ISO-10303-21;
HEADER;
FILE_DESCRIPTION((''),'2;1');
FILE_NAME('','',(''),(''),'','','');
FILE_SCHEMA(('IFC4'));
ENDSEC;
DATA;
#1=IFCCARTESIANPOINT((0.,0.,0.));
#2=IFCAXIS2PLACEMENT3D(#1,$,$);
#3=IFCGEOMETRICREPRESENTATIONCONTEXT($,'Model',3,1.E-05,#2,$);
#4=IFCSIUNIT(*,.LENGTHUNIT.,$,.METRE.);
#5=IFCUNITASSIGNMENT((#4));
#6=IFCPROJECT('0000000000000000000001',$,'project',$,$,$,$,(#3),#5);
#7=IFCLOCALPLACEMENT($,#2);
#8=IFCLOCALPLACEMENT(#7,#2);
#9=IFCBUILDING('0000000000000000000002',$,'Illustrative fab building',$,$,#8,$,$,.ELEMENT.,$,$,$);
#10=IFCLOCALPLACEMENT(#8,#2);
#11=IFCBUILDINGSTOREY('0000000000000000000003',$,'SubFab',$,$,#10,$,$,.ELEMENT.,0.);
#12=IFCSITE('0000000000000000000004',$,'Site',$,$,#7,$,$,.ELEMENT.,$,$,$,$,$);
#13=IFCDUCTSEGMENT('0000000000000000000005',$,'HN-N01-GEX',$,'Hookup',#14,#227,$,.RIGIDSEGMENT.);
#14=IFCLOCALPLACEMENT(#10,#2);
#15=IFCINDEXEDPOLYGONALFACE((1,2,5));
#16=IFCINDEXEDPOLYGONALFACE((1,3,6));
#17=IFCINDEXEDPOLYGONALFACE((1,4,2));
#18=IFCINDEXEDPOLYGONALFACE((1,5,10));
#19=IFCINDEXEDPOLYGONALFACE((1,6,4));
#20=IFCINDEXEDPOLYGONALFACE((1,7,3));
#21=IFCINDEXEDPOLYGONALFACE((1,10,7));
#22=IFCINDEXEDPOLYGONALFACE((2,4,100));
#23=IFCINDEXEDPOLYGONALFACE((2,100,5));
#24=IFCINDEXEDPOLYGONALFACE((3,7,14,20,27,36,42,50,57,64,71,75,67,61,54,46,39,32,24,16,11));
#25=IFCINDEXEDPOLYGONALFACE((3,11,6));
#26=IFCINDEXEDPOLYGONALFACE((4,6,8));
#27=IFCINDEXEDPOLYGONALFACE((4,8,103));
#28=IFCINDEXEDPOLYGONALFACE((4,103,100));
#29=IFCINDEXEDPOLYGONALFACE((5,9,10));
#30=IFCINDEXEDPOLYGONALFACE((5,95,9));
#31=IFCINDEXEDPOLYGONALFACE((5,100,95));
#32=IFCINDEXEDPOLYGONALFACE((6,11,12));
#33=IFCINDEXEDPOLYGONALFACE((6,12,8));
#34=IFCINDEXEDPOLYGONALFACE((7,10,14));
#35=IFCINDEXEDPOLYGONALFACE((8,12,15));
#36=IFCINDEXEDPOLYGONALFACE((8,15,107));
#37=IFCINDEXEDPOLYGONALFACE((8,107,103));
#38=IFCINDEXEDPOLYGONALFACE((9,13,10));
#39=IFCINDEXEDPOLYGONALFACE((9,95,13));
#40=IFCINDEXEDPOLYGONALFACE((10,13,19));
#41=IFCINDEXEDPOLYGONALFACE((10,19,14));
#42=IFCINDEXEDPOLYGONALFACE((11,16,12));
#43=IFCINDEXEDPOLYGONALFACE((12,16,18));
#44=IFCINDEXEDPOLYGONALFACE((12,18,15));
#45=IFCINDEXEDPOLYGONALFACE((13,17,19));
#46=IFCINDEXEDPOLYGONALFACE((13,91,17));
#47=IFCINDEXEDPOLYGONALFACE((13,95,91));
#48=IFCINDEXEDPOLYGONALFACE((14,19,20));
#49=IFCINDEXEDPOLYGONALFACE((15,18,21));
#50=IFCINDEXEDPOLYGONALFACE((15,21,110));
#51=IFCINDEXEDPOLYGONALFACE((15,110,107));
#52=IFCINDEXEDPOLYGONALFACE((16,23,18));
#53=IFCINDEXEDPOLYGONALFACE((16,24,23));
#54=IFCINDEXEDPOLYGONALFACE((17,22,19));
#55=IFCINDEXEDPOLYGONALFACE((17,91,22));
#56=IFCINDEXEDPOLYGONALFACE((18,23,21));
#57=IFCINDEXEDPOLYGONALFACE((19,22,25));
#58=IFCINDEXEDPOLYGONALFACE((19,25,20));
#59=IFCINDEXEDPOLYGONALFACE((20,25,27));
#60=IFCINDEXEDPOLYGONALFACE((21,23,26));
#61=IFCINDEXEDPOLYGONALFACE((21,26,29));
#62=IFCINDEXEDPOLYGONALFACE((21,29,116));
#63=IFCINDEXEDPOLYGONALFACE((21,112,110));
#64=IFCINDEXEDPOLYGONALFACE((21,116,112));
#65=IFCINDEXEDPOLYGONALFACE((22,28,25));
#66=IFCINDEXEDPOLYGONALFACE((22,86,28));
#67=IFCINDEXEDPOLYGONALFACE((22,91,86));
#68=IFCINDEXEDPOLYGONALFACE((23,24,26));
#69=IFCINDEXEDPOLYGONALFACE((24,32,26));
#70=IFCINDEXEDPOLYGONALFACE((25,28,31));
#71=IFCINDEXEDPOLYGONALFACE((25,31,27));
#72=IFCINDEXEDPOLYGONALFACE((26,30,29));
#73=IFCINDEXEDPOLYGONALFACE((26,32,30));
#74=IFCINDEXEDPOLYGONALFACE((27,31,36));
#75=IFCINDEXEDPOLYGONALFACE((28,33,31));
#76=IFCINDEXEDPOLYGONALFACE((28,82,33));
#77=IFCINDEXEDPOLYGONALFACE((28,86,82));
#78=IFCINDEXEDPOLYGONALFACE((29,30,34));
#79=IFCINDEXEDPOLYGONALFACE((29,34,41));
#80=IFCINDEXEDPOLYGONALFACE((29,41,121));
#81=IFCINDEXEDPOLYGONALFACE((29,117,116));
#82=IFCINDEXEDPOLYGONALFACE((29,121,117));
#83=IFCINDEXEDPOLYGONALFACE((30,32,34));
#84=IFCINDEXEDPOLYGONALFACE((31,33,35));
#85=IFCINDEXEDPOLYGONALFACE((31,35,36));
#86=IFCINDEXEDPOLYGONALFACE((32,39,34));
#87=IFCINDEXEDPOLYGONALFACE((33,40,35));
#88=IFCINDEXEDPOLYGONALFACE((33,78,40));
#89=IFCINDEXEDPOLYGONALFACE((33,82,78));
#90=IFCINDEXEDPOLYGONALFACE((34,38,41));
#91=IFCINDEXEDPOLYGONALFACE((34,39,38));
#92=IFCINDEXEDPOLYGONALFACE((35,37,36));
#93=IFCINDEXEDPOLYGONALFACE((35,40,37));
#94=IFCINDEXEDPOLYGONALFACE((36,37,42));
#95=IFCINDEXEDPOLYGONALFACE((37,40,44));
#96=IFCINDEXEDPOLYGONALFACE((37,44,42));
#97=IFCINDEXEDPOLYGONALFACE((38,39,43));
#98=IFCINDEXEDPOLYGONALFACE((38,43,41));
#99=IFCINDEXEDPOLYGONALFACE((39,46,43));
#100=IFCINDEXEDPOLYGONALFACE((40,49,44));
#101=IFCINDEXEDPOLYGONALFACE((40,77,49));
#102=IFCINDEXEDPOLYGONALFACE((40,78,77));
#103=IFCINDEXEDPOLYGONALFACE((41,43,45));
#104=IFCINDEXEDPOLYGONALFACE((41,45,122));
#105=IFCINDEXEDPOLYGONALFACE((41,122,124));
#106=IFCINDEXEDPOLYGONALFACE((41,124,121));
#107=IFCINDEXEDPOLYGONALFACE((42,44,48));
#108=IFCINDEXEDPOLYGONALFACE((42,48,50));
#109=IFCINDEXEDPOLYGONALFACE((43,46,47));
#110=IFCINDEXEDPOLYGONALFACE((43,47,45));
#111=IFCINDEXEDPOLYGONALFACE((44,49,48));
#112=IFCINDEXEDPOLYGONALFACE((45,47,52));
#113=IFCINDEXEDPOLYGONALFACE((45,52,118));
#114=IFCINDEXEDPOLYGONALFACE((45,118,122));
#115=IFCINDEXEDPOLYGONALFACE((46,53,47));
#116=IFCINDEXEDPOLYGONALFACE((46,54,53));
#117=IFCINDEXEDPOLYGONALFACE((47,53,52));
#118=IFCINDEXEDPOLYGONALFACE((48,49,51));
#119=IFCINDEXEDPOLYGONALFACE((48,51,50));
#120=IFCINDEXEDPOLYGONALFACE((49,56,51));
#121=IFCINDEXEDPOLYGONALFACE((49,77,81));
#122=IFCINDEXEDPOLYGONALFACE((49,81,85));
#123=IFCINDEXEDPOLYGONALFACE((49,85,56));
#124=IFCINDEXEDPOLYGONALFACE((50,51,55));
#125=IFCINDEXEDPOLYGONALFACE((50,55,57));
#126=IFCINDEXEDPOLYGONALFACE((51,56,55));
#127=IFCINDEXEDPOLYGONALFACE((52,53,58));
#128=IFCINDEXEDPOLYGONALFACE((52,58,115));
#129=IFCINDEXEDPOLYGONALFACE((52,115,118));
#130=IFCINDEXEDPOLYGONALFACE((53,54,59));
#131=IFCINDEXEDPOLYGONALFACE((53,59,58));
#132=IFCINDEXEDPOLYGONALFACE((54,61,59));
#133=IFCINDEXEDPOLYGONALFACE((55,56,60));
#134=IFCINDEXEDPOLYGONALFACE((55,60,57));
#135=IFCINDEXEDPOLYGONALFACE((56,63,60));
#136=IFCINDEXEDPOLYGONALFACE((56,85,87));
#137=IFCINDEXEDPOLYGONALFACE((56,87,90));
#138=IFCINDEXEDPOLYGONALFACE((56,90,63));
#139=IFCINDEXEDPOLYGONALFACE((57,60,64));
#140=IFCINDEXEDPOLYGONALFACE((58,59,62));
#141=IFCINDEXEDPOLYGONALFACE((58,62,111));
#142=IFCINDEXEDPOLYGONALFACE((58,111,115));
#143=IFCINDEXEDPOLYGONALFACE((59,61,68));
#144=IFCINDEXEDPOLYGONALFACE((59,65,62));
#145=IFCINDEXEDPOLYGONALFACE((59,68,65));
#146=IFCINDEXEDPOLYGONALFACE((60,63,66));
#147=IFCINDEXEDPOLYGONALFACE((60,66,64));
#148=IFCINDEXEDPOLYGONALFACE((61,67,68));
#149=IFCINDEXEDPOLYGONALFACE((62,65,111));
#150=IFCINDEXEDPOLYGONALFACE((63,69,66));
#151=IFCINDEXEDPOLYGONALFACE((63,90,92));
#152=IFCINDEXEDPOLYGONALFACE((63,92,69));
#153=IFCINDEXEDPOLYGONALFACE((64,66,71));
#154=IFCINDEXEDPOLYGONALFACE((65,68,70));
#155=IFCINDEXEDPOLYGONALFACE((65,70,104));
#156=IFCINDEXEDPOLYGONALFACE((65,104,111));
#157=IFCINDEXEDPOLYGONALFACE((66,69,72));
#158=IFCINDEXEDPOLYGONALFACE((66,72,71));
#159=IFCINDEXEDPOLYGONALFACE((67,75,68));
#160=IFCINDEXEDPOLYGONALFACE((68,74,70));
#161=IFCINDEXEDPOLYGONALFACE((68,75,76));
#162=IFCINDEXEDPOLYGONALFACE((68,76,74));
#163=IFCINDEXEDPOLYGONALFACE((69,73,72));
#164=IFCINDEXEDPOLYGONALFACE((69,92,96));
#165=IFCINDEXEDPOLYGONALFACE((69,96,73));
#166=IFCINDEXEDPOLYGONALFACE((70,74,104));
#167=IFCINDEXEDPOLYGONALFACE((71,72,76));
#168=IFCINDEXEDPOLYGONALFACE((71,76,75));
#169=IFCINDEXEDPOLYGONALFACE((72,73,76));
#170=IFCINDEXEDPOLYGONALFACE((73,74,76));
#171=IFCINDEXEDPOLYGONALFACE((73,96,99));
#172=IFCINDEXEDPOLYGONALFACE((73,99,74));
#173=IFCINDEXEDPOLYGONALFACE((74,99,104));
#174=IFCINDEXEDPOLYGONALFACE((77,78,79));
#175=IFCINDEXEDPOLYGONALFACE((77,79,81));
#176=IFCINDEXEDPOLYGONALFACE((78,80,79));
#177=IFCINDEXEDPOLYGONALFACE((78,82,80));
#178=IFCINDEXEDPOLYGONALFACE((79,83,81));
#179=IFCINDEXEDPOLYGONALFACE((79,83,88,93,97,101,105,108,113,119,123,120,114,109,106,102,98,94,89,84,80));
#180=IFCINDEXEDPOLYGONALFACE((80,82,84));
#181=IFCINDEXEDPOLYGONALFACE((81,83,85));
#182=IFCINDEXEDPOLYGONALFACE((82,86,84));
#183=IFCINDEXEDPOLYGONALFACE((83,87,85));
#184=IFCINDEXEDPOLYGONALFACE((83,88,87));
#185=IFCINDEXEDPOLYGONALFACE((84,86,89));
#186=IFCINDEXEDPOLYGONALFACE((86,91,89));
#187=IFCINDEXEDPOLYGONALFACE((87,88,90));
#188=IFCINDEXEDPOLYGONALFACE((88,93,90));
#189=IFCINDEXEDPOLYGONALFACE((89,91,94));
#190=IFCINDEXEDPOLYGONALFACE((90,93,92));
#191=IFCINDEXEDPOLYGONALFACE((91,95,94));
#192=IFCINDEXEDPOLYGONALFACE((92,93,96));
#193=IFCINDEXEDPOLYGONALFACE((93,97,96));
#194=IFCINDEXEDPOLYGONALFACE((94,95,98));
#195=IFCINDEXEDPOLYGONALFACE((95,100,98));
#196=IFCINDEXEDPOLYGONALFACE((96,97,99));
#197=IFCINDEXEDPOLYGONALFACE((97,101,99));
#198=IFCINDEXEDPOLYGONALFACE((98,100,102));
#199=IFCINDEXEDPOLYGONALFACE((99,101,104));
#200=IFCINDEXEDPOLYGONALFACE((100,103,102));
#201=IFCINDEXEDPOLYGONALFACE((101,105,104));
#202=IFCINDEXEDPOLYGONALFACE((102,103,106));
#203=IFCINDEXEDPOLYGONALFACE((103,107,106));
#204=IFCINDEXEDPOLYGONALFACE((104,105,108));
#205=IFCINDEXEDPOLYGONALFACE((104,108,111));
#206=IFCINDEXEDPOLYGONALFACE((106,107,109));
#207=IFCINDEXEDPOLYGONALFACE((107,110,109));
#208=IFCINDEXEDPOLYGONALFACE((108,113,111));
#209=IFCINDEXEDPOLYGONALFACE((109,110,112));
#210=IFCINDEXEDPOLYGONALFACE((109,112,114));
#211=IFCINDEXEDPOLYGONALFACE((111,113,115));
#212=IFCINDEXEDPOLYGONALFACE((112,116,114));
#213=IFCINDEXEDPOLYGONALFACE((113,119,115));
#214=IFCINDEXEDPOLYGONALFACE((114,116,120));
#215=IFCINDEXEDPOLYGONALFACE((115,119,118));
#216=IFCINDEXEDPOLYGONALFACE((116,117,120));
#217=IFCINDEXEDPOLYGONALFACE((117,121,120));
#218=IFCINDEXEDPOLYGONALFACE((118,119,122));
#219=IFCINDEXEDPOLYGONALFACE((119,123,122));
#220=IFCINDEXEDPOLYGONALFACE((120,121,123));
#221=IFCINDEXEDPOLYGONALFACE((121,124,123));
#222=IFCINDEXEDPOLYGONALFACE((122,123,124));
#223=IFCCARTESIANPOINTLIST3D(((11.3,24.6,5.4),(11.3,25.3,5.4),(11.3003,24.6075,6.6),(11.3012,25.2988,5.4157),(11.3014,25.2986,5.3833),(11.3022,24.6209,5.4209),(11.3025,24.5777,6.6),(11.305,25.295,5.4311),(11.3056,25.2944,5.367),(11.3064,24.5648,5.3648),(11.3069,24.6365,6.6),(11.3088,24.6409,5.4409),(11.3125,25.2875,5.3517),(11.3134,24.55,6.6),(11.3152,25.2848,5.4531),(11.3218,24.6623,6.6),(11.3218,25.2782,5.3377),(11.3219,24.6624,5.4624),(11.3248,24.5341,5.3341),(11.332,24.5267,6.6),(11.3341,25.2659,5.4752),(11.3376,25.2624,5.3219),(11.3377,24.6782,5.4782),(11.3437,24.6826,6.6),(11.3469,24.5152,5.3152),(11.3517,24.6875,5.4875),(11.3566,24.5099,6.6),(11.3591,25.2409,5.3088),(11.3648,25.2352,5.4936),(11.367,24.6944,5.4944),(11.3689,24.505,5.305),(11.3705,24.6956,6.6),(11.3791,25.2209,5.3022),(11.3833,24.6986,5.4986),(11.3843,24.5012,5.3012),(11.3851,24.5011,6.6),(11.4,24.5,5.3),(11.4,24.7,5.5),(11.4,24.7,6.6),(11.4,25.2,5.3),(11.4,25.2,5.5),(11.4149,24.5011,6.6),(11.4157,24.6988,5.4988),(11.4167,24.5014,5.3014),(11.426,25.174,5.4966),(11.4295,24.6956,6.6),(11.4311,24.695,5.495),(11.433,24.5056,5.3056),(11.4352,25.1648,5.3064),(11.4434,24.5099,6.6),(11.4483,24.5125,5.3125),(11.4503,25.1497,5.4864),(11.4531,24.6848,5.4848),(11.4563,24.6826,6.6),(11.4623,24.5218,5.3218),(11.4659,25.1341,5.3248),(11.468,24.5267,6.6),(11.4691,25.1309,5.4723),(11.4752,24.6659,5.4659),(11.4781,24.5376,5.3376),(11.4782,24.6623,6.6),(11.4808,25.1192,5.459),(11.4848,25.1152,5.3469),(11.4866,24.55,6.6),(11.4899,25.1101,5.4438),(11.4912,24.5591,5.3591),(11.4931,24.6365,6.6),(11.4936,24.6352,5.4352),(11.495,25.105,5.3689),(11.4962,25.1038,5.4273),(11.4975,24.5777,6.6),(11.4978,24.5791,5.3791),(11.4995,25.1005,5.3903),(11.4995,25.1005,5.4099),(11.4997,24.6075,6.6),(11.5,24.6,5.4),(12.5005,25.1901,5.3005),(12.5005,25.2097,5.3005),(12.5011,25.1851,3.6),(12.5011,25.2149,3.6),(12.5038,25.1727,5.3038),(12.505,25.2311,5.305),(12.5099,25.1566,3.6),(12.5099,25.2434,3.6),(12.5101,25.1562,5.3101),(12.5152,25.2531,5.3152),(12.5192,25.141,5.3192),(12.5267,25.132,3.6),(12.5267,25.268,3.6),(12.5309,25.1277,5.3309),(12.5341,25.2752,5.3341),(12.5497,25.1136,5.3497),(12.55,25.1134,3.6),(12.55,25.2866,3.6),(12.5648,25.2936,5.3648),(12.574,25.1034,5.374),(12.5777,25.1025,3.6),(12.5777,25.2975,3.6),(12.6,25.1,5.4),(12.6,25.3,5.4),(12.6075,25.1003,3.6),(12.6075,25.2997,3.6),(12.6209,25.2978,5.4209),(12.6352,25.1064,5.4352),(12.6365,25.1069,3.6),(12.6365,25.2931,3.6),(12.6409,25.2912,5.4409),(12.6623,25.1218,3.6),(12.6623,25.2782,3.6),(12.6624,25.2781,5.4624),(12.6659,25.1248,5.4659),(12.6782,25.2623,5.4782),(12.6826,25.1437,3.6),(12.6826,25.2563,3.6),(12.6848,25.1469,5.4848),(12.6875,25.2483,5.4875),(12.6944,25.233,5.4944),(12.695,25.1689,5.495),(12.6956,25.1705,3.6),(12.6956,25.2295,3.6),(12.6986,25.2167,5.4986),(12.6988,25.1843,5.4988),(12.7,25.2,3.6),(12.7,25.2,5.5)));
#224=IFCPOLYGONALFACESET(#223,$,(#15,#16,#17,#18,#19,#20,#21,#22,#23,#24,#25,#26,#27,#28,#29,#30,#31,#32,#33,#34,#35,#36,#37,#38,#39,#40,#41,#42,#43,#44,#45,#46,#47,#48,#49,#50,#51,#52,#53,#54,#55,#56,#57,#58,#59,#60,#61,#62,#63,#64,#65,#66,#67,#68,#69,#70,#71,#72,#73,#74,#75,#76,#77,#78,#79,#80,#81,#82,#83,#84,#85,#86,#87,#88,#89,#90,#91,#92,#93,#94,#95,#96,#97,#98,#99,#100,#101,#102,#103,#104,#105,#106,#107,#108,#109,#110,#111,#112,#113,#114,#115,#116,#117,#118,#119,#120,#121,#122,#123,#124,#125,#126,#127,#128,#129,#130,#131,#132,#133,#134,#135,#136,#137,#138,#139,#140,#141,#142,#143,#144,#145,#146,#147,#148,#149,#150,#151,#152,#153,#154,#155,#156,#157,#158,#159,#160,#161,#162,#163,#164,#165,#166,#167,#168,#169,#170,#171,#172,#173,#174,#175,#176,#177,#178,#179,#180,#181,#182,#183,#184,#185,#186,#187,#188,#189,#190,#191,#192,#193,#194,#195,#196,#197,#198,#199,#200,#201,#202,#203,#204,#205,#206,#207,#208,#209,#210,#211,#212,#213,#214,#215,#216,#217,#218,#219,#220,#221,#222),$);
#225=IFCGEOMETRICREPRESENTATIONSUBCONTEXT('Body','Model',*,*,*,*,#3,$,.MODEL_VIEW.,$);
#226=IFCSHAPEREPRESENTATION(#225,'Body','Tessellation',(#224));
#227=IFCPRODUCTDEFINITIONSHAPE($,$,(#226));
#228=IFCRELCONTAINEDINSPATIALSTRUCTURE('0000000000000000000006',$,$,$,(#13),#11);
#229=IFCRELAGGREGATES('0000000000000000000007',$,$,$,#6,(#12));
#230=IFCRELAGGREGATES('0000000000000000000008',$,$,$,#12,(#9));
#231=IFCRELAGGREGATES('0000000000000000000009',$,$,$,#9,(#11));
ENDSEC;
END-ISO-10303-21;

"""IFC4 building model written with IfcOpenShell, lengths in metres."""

from ifc_helpers import new_model, entity, si_unit, origin, place, context, subcontext, project, spatial, element, save


model = new_model("IFC4")

# Units and contexts
model_context = context("Model", 3, precision=1e-05, world=origin())
body_context = subcontext(model_context, "Body", "Model", "MODEL_VIEW")
ifc_project = project(units=[si_unit("LENGTHUNIT", "METRE")], contexts=[model_context])

# Site, building, storey
site_placement = place(None, origin())
site = spatial("IfcSite", under=ifc_project, at=site_placement, Name="Site", CompositionType="ELEMENT")
building_placement = place(site_placement, origin())
building = spatial("IfcBuilding", under=site, at=building_placement, Name="Illustrative fab building", CompositionType="ELEMENT")
storey_placement = place(building_placement, origin())
storey = spatial("IfcBuildingStorey", under=building, at=storey_placement, Name="SubFab", CompositionType="ELEMENT", Elevation=0.0)

# Duct segment
duct_segment_1_placement = place(storey_placement, origin())
element("IfcDuctSegment", 1, at=duct_segment_1_placement, inside=storey, Name="HN-N01-GEX", ObjectType="Hookup", PredefinedType="RIGIDSEGMENT", context=body_context, shape_type="AdvancedSweptSolid", body=[
    entity("IfcSweptDiskSolid", entity("IfcPolyline", [entity("IfcCartesianPoint", [12.6, 25.2, 3.6]), entity("IfcCartesianPoint", [12.6, 25.2, 5.4]), entity("IfcCartesianPoint", [11.4, 25.2, 5.4]), entity("IfcCartesianPoint", [11.4, 24.6, 5.4]), entity("IfcCartesianPoint", [11.4, 24.6, 6.6])]), 0.1),
])

save(model, "model.ifc")
